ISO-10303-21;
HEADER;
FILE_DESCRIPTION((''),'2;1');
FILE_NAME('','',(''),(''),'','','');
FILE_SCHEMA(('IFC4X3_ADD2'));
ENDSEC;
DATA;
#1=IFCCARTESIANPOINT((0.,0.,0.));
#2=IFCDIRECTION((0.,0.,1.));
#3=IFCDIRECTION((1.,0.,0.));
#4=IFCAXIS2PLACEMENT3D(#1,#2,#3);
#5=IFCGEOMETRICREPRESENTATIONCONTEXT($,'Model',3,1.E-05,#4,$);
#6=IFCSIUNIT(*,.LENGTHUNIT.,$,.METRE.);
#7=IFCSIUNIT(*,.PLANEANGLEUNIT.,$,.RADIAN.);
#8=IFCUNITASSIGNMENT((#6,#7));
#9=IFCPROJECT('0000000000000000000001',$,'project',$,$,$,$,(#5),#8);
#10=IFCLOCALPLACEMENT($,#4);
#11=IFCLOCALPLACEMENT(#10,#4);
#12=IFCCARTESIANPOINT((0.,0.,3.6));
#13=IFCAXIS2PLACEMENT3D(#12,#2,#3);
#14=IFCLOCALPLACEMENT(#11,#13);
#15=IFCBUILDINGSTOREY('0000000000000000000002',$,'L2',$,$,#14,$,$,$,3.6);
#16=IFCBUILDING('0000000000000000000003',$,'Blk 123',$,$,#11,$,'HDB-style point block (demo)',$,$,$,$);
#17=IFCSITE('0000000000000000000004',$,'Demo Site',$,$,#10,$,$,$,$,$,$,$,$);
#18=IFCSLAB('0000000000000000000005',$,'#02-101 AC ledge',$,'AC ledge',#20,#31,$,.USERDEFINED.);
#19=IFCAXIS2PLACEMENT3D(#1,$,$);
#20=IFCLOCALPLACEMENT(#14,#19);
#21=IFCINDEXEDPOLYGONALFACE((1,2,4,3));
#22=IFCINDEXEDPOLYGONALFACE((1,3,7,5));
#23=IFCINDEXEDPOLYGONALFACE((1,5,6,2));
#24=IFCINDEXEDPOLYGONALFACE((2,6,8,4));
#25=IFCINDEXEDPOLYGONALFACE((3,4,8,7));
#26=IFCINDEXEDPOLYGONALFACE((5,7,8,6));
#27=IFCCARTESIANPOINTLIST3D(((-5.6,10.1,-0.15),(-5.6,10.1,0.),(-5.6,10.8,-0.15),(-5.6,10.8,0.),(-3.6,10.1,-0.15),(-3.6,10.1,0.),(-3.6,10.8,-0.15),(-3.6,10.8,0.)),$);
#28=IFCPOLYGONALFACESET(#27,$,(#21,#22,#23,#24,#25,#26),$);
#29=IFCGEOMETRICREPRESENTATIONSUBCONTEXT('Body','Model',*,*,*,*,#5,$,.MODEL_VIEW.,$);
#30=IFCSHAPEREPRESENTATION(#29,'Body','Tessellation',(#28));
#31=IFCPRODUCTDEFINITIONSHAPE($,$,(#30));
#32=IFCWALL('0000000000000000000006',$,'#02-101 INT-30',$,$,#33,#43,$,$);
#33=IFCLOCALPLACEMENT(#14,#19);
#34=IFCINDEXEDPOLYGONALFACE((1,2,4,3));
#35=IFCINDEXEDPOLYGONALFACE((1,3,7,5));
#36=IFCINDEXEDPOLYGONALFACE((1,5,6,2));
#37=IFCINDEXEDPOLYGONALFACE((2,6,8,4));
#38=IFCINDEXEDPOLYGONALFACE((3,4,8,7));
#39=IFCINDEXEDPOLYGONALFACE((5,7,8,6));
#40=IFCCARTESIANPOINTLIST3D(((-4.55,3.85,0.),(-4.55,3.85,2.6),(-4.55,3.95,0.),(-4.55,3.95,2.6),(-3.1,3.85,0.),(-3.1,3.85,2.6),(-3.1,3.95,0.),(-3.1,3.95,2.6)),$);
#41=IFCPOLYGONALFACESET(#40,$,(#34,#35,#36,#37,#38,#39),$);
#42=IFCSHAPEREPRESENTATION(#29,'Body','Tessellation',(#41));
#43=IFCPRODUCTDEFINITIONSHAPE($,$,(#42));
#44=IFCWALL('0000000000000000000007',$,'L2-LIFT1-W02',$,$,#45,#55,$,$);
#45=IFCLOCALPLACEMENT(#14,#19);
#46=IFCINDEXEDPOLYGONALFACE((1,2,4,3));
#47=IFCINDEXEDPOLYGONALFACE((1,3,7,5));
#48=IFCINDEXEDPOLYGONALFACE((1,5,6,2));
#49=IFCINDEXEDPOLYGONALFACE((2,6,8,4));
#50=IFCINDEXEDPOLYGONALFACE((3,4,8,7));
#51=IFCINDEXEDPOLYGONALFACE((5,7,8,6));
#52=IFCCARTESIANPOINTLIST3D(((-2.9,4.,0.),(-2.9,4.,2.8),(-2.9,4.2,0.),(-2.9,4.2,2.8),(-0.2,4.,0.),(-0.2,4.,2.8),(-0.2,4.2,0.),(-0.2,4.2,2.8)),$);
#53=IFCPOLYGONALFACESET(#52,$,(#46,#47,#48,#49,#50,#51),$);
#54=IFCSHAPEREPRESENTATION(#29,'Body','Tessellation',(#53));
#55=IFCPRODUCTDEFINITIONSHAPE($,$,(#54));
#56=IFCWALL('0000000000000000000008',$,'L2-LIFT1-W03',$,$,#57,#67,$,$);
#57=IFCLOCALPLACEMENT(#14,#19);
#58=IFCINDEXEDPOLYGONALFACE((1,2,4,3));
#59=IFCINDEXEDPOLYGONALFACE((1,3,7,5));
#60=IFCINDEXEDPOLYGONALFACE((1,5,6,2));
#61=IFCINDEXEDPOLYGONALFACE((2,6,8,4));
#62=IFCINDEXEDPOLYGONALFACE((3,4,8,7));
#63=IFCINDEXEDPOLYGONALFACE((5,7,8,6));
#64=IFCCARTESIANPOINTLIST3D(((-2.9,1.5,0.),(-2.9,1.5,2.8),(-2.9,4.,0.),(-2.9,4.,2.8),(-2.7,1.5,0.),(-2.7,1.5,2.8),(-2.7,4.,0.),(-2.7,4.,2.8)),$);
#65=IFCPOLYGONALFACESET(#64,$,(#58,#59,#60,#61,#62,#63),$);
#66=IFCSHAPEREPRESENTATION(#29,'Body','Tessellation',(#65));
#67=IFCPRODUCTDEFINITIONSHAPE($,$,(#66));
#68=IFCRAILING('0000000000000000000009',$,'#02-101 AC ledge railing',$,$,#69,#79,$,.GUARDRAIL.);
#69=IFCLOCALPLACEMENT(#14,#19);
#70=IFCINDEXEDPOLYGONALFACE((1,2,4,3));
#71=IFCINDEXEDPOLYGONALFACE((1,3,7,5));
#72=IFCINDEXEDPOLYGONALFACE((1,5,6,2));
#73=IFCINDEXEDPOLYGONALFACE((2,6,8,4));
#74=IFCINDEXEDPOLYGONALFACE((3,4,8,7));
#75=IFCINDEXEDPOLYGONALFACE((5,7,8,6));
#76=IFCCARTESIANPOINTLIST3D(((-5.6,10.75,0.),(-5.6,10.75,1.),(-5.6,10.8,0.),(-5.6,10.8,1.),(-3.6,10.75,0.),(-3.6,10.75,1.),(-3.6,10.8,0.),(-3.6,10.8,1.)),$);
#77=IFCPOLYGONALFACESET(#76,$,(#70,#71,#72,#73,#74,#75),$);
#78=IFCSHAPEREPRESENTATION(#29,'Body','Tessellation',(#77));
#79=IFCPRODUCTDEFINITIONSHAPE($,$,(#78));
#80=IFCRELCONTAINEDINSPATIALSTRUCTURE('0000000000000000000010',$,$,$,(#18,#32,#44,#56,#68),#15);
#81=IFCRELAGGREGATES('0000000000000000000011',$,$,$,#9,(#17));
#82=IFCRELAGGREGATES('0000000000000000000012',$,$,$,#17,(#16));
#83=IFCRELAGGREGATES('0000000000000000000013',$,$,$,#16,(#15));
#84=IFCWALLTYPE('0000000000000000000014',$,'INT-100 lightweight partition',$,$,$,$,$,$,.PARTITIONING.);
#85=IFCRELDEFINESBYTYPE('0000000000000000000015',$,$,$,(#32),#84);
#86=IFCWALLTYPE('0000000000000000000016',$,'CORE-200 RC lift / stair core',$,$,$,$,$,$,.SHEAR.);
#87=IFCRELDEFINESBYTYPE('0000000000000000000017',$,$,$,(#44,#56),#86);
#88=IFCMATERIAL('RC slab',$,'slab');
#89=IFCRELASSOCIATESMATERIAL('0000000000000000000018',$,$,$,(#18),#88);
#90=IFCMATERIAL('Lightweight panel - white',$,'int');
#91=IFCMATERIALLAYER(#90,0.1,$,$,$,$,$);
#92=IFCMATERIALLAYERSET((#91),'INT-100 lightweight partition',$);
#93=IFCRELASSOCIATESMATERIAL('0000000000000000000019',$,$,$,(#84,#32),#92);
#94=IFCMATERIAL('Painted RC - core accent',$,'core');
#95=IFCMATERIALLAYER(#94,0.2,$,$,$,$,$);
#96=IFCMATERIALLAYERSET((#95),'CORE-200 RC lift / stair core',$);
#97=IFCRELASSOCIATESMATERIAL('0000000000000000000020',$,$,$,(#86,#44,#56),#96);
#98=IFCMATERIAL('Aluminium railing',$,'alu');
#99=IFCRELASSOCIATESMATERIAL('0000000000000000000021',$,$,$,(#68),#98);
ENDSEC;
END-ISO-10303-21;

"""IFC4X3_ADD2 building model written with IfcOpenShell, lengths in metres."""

from ifc_helpers import new_model, si_unit, frame, origin, origin_with_axes, place, context, subcontext, project, spatial, polyline, indexed_curve, outline, extrude, material, layer, layer_set, layer_usage, type_object, element, save


model = new_model("IFC4X3_ADD2")

# Units and contexts
model_context = context("Model", 3, precision=1e-05, world=origin_with_axes())
body_context = subcontext(model_context, "Body", "Model", "MODEL_VIEW")
ifc_project = project(units=[si_unit("LENGTHUNIT", "METRE"), si_unit("PLANEANGLEUNIT", "RADIAN")], contexts=[model_context])

# Site, building, storey
site_placement = place(None, origin_with_axes())
site = spatial("IfcSite", under=ifc_project, at=site_placement, Name="Demo Site")
building_placement = place(site_placement, origin_with_axes())
building = spatial("IfcBuilding", under=site, at=building_placement, Name="Blk 123", LongName="HDB-style point block (demo)")
storey_placement = place(building_placement, frame((0.0, 0.0, 3.6), z_axis=(0.0, 0.0, 1.0), x_axis=(1.0, 0.0, 0.0)))
storey = spatial("IfcBuildingStorey", under=building, at=storey_placement, Name="L2", Elevation=3.6)

# Slab
ifc_material_1 = material(Name="RC slab", Category="slab")
slab_placement = place(storey_placement, frame((-4.6, 10.45, -0.15), z_axis=(0.0, 0.0, 1.0), x_axis=(1.0, 0.0, 0.0)))
element("IfcSlab", 1, at=slab_placement, inside=storey, material=ifc_material_1, Name="#02-101 AC ledge", ObjectType="AC ledge", PredefinedType="USERDEFINED", context=body_context, shape_type="SweptSolid", body=[
    extrude(outline(polyline([(-1.0, -0.35), (1.0, -0.35), (1.0, 0.35), (-1.0, 0.35), (-1.0, -0.35)])), origin(), (0.0, 0.0, 1.0), 0.15),
])

# Shared definitions
ifc_material_2 = material(Name="Lightweight panel - white", Category="int")
ifc_layer_1 = layer(ifc_material_2, 0.1)
ifc_layer_set_1 = layer_set([ifc_layer_1], Name="INT-100 lightweight partition")
ifc_layer_usage_1 = layer_usage(ifc_layer_set_1, "AXIS2", "POSITIVE", -0.05)
wall_type_1 = type_object("IfcWallType", Name="INT-100 lightweight partition", PredefinedType="PARTITIONING", material=ifc_layer_set_1)

# Wall
wall_1_placement = place(storey_placement, frame((-3.1, 3.9, 0.0), z_axis=(0.0, 0.0, 1.0), x_axis=(-1.0, 0.0, 0.0)))
element("IfcWall", 2, at=wall_1_placement, inside=storey, type_object=wall_type_1, material=ifc_layer_usage_1, Name="#02-101 INT-30", context=body_context, shape_type="SweptSolid", body=[
    extrude(outline(indexed_curve([(0.0, 0.0), (0.0, 0.1), (1.45, 0.1), (1.45, 0.0), (0.0, 0.0)], self_intersect=False)), frame((0.0, -0.05, 0.0), z_axis=(0.0, 0.0, 1.0), x_axis=(1.0, 0.0, 0.0)), (0.0, 0.0, 1.0), 2.6),
])

# Walls
ifc_material_3 = material(Name="Painted RC - core accent", Category="core")
ifc_layer_2 = layer(ifc_material_3, 0.2)
ifc_layer_set_2 = layer_set([ifc_layer_2], Name="CORE-200 RC lift / stair core")
ifc_layer_usage_2 = layer_usage(ifc_layer_set_2, "AXIS2", "POSITIVE", 0.0)
wall_type_2 = type_object("IfcWallType", Name="CORE-200 RC lift / stair core", PredefinedType="SHEAR", material=ifc_layer_set_2)
wall_2_placement = place(storey_placement, frame((-0.2, 4.2, 0.0), z_axis=(0.0, 0.0, 1.0), x_axis=(-1.0, 0.0, 0.0)))
element("IfcWall", 3, at=wall_2_placement, inside=storey, type_object=wall_type_2, material=ifc_layer_usage_2, Name="L2-LIFT1-W02", context=body_context, shape_type="SweptSolid", body=[
    extrude(outline(indexed_curve([(0.0, 0.0), (0.0, 0.2), (2.7, 0.2), (2.7, 0.0), (0.0, 0.0)], self_intersect=False)), origin_with_axes(), (0.0, 0.0, 1.0), 2.8),
])
wall_3_placement = place(storey_placement, frame((-2.9, 4.0, 0.0), z_axis=(0.0, 0.0, 1.0), x_axis=(0.0, -1.0, 0.0)))
element("IfcWall", 4, at=wall_3_placement, inside=storey, type_object=wall_type_2, material=ifc_layer_usage_2, Name="L2-LIFT1-W03", context=body_context, shape_type="SweptSolid", body=[
    extrude(outline(indexed_curve([(0.0, 0.0), (0.0, 0.2), (2.5, 0.2), (2.5, 0.0), (0.0, 0.0)], self_intersect=False)), origin_with_axes(), (0.0, 0.0, 1.0), 2.8),
])

# Railing
ifc_material_4 = material(Name="Aluminium railing", Category="alu")
railing_placement = place(storey_placement, frame((-4.6, 10.775, 0.0), z_axis=(0.0, 0.0, 1.0), x_axis=(1.0, 0.0, 0.0)))
element("IfcRailing", 5, at=railing_placement, inside=storey, material=ifc_material_4, Name="#02-101 AC ledge railing", PredefinedType="GUARDRAIL", context=body_context, shape_type="SweptSolid", body=[
    extrude(outline(polyline([(-1.0, -0.025), (1.0, -0.025), (1.0, 0.025), (-1.0, 0.025), (-1.0, -0.025)])), origin(), (0.0, 0.0, 1.0), 1.0),
])

save(model, "model.ifc")
